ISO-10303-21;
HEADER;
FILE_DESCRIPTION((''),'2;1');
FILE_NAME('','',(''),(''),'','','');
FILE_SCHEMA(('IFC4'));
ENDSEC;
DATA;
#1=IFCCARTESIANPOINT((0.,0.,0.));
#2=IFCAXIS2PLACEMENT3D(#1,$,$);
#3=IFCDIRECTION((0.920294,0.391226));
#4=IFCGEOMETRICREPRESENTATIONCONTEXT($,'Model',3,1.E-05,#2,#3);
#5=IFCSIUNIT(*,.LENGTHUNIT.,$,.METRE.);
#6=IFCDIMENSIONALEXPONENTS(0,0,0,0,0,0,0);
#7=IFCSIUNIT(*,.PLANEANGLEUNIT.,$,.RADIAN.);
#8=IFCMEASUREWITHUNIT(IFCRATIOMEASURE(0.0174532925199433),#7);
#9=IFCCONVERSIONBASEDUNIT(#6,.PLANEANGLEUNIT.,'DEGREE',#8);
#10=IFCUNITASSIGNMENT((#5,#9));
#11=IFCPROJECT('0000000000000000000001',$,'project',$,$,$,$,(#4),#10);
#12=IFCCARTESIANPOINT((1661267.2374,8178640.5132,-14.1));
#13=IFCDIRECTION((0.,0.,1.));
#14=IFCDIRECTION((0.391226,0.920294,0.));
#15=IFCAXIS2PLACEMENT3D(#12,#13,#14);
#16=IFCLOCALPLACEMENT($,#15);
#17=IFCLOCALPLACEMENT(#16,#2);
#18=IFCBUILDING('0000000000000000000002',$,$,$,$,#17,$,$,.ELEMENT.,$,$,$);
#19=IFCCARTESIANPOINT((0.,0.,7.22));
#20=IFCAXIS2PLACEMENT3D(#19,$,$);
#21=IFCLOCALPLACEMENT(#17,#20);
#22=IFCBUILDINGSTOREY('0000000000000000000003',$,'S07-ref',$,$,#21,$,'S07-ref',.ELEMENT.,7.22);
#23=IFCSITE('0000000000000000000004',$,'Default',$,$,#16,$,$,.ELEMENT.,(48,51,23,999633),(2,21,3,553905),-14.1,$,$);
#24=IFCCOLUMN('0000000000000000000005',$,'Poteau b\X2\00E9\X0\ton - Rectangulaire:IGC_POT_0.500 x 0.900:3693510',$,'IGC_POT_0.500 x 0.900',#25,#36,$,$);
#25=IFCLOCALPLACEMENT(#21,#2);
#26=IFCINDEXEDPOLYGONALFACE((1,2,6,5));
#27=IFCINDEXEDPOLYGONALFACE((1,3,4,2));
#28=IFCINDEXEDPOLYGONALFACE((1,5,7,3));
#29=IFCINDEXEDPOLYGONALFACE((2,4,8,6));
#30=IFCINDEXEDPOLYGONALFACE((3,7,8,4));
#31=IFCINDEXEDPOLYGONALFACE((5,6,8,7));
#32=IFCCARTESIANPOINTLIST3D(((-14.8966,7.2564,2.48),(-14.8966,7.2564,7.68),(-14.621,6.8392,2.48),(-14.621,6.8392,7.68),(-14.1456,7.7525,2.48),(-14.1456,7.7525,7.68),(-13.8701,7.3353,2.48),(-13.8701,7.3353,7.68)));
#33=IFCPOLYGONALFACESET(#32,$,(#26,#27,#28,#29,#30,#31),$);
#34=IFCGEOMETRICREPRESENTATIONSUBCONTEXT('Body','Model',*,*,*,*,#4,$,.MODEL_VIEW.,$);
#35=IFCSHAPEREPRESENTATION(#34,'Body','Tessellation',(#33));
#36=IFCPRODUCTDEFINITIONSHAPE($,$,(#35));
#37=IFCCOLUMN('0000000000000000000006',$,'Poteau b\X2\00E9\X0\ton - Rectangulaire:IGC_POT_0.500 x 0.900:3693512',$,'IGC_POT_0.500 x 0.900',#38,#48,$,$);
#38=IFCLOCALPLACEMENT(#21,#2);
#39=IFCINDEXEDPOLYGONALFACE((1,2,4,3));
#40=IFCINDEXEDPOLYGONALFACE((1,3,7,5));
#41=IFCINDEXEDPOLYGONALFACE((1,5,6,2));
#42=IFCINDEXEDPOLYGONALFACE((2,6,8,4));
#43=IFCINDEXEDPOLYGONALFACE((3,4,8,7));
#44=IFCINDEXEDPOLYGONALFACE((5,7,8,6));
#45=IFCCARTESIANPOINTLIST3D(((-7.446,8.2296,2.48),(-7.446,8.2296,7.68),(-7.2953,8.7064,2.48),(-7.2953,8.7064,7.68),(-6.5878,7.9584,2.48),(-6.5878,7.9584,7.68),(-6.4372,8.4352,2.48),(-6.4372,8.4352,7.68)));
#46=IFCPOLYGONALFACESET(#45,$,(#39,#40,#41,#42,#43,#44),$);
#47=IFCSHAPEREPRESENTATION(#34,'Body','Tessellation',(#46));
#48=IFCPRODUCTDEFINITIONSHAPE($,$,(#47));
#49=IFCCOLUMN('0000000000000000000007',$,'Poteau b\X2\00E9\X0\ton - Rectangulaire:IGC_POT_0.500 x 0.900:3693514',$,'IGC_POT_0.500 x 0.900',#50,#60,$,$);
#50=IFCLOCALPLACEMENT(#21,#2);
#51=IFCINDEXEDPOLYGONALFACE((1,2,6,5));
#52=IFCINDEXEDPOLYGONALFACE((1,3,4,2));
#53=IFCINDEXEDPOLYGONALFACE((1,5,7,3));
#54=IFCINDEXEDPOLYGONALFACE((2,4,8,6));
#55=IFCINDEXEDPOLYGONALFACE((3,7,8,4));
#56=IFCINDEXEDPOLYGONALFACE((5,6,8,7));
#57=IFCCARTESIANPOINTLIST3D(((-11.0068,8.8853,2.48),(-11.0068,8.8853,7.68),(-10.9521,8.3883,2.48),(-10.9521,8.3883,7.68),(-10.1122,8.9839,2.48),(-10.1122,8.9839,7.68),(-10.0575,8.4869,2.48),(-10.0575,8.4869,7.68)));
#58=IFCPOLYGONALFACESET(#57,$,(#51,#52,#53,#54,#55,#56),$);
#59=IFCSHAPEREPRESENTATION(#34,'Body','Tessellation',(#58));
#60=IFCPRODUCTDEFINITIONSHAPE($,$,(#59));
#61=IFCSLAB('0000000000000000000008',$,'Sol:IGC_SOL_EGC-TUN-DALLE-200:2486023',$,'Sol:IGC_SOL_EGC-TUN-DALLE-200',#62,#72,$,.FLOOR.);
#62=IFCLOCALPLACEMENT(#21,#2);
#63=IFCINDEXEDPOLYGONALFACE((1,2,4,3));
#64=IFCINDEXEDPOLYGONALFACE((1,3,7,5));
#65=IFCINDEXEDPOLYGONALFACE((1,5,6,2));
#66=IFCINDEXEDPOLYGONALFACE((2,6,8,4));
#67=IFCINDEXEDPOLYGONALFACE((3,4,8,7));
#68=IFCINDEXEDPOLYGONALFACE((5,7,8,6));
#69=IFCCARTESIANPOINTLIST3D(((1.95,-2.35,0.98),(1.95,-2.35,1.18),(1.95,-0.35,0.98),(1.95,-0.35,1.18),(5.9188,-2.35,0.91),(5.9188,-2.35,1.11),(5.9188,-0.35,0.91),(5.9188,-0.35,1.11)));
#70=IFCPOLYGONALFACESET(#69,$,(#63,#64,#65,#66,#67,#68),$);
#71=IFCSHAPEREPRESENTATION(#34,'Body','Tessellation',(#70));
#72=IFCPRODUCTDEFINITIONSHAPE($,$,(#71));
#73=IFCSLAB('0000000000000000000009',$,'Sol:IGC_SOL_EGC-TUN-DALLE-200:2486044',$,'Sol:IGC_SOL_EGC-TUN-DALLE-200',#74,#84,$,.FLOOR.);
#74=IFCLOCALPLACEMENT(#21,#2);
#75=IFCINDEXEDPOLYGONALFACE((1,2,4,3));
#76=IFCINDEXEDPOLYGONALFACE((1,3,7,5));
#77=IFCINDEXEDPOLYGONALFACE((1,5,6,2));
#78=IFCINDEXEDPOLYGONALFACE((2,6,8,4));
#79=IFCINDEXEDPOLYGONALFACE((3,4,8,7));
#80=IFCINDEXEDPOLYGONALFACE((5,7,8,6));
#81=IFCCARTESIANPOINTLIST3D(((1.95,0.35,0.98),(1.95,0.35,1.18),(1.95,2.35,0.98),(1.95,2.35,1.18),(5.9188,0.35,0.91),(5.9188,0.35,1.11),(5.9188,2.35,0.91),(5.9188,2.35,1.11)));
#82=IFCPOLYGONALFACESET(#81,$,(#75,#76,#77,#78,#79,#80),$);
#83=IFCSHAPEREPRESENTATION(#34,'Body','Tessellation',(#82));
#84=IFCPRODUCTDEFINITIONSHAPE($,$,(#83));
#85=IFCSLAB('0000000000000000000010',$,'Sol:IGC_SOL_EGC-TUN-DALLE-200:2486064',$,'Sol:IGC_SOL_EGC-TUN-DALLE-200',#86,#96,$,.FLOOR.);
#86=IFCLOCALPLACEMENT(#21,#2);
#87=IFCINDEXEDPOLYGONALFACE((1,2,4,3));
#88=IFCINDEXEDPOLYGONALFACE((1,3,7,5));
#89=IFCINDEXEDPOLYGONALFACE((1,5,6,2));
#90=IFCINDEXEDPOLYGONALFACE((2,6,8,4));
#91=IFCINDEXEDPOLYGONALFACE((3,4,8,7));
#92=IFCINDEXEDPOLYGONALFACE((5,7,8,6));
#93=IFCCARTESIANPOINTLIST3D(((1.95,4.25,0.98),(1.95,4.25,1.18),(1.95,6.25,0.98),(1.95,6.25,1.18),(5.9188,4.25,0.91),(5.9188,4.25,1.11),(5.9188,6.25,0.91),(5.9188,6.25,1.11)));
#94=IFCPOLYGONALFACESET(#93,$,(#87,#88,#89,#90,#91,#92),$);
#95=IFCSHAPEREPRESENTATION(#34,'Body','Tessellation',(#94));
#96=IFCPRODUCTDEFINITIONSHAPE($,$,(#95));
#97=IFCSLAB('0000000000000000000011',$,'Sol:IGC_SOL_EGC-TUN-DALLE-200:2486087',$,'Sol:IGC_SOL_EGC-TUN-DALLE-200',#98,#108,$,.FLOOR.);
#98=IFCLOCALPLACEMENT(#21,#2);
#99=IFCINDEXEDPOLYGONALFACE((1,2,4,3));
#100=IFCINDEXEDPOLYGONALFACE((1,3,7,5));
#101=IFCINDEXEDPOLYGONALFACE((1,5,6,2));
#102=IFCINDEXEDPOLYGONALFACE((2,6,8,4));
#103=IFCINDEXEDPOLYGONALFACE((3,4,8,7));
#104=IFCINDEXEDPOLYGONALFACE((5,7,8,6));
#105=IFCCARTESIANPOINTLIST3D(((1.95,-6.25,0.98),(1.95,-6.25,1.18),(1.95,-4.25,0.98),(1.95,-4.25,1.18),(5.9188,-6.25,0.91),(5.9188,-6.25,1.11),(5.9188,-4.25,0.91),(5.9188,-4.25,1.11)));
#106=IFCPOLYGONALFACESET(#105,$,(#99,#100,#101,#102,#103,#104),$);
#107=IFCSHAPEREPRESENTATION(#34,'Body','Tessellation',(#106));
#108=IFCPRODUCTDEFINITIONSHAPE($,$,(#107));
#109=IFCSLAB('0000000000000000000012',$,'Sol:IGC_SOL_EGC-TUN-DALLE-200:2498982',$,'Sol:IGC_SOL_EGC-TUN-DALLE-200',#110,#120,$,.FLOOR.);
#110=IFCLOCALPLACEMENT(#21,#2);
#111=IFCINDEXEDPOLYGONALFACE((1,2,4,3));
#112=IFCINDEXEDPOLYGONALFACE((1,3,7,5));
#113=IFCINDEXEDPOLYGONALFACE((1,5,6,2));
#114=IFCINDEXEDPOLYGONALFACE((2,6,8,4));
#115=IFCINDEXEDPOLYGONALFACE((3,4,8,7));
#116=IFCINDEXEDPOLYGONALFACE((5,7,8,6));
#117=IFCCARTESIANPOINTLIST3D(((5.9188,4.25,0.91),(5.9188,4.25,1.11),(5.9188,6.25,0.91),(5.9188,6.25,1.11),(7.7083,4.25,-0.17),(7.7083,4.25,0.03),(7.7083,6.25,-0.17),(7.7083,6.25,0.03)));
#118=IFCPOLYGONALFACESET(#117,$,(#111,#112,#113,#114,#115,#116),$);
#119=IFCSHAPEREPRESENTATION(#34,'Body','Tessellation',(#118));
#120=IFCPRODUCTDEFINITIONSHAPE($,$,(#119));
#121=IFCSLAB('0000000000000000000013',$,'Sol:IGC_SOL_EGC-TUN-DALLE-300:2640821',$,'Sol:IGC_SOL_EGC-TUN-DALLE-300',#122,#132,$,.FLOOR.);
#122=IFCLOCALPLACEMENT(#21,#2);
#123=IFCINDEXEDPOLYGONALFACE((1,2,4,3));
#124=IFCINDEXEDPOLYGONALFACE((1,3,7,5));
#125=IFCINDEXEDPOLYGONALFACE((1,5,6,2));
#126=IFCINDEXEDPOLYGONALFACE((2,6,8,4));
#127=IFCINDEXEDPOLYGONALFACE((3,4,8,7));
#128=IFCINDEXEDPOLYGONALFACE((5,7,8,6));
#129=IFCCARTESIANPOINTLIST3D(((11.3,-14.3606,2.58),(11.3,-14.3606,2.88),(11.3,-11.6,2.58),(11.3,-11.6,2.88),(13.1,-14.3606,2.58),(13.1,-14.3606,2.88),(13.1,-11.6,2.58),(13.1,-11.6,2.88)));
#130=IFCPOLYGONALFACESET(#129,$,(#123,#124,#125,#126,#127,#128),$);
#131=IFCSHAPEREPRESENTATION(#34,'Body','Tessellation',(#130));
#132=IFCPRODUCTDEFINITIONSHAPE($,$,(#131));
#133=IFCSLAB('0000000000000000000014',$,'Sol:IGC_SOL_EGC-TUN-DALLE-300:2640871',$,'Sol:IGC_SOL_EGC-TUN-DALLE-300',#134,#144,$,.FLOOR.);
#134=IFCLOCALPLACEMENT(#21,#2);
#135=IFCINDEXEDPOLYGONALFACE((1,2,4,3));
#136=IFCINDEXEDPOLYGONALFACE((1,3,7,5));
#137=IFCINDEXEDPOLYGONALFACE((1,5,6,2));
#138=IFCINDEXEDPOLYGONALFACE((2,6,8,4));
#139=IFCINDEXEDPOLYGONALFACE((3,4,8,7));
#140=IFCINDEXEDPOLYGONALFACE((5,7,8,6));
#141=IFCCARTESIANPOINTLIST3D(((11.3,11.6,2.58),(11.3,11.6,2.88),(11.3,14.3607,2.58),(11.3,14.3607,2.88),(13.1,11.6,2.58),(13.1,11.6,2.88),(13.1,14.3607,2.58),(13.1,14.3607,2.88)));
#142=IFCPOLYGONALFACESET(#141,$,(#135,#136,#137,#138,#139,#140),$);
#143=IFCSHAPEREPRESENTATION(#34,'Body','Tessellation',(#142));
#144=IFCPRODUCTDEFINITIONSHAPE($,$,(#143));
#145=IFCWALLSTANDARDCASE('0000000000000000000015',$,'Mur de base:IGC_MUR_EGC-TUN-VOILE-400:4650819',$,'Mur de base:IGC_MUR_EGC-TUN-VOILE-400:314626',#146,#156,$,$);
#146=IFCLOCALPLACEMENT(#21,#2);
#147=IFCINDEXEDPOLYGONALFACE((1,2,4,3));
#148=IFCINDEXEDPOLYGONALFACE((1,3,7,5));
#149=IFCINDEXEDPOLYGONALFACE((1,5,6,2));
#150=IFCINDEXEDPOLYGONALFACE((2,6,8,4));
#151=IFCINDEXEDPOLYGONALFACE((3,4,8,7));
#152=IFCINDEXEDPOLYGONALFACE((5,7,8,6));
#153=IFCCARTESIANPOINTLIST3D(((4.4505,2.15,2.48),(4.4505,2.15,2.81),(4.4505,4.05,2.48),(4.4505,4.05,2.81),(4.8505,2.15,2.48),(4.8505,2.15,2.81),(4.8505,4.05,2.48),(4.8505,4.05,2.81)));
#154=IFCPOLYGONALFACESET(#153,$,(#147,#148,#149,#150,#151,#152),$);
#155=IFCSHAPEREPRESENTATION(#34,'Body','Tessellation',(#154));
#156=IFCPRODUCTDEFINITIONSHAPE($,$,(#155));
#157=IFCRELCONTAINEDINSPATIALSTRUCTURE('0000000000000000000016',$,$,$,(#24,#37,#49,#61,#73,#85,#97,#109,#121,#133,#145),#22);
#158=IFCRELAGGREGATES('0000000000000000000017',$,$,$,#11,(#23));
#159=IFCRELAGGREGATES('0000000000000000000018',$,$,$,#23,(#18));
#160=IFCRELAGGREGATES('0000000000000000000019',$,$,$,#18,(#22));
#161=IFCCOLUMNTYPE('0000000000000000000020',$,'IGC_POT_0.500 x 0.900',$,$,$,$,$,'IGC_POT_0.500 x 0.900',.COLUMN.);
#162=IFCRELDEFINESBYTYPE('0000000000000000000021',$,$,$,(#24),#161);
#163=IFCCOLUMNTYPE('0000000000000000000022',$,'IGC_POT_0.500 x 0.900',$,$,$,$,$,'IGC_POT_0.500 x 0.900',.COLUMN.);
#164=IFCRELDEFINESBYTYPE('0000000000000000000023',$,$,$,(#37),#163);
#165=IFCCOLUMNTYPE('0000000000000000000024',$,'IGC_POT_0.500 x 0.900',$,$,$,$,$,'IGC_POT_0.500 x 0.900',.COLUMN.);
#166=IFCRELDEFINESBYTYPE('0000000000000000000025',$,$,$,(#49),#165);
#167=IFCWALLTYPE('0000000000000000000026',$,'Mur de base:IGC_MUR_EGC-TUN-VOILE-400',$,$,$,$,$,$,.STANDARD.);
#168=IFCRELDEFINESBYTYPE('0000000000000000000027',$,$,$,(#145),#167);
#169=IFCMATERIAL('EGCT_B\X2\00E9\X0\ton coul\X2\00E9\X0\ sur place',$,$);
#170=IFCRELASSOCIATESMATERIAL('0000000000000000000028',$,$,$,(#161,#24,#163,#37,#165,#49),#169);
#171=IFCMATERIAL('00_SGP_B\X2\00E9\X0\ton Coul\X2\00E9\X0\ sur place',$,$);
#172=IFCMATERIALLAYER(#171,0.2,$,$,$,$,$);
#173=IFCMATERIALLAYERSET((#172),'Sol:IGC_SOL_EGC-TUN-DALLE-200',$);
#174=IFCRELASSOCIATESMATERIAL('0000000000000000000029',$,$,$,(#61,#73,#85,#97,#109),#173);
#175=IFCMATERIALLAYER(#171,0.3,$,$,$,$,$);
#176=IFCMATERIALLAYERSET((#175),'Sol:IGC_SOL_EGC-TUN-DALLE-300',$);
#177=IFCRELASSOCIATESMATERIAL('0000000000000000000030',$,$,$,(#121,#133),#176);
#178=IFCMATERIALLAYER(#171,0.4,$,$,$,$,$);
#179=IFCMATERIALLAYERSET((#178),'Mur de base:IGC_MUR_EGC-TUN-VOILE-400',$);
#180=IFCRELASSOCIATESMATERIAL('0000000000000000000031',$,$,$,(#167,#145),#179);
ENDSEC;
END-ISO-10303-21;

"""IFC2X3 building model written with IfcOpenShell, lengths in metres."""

from ifc_helpers import new_model, entity, si_unit, converted_unit, direction, frame, frame_2d, origin, origin_2d_with_axis, place, context, subcontext, project, spatial, polyline, rectangle, outline, extrude, clip, halfspace, source, transform, mapped, material, layer, layer_set, layer_usage, type_object, type_shapes, element, save


model = new_model("IFC2X3")

# Units and contexts
model_context = context("Model", 3, precision=1e-05, world=origin(), true_north=direction((0.920294, 0.391226)))
body_context = subcontext(model_context, "Body", "Model", "MODEL_VIEW")
ifc_project = project(units=[si_unit("LENGTHUNIT", "METRE"), converted_unit("PLANEANGLEUNIT", "DEGREE", entity("IfcRatioMeasure", 0.0174532925199433), si_unit("PLANEANGLEUNIT", "RADIAN"), dimensions=[0, 0, 0, 0, 0, 0, 0])], contexts=[model_context])

# Site, building, storey
site_placement = place(None, frame((1661267.2374, 8178640.5132, -14.1), z_axis=(0.0, 0.0, 1.0), x_axis=(0.391226, 0.920294, 0.0)))
site = spatial("IfcSite", under=ifc_project, at=site_placement, Name="Default", CompositionType="ELEMENT", RefLatitude=(48, 51, 23, 999633), RefLongitude=(2, 21, 3, 553905), RefElevation=-14.1)
building_placement = place(site_placement, origin())
building = spatial("IfcBuilding", under=site, at=building_placement, CompositionType="ELEMENT")
storey_placement = place(building_placement, frame((0.0, 0.0, 7.22)))
storey = spatial("IfcBuildingStorey", under=building, at=storey_placement, Name="S07-ref", LongName="S07-ref", CompositionType="ELEMENT", Elevation=7.22)

# Columns
ifc_material_1 = material(Name="EGCT_Béton coulé sur place")
column_type_1 = type_object("IfcColumnType", Name="IGC_POT_0.500 x 0.900", ElementType="IGC_POT_0.500 x 0.900", PredefinedType="COLUMN", material=ifc_material_1)
shared_shape_1 = source(origin(), body_context, "Body", "SweptSolid", [
    extrude(rectangle(XDim=0.5, YDim=0.9, at=origin_2d_with_axis()), frame((-14.3833, 7.2959, 9.7), z_axis=(0.0, 0.0, 1.0), x_axis=(-0.551164, 0.834397, 0.0)), (0.0, 0.0, 1.0), 5.2),
])
type_shapes(column_type_1, [shared_shape_1])
column_1_placement = place(storey_placement, frame((0.0, 0.0, -7.22)))
element("IfcColumn", 1, at=column_1_placement, inside=storey, type_object=column_type_1, material=ifc_material_1, Name="Poteau béton - Rectangulaire:IGC_POT_0.500 x 0.900:3693510", ObjectType="IGC_POT_0.500 x 0.900", context=body_context, shape_type="MappedRepresentation", body=[
    mapped(shared_shape_1, transform((0.0, 0.0, 0.0), scale=1.0)),
])
column_type_2 = type_object("IfcColumnType", Name="IGC_POT_0.500 x 0.900", ElementType="IGC_POT_0.500 x 0.900", PredefinedType="COLUMN", material=ifc_material_1)
shared_shape_2 = source(origin(), body_context, "Body", "SweptSolid", [
    extrude(rectangle(XDim=0.9, YDim=0.5, at=origin_2d_with_axis()), frame((-6.9416, 8.3324, 9.7), z_axis=(0.0, 0.0, 1.0), x_axis=(-0.953513, 0.301352, 0.0)), (0.0, 0.0, 1.0), 5.2),
])
type_shapes(column_type_2, [shared_shape_2])
column_2_placement = place(storey_placement, frame((0.0, 0.0, -7.22)))
element("IfcColumn", 2, at=column_2_placement, inside=storey, type_object=column_type_2, material=ifc_material_1, Name="Poteau béton - Rectangulaire:IGC_POT_0.500 x 0.900:3693512", ObjectType="IGC_POT_0.500 x 0.900", context=body_context, shape_type="MappedRepresentation", body=[
    mapped(shared_shape_2, transform((0.0, 0.0, 0.0), scale=1.0)),
])
column_type_3 = type_object("IfcColumnType", Name="IGC_POT_0.500 x 0.900", ElementType="IGC_POT_0.500 x 0.900", PredefinedType="COLUMN", material=ifc_material_1)
shared_shape_3 = source(origin(), body_context, "Body", "SweptSolid", [
    extrude(rectangle(XDim=0.9, YDim=0.5, at=frame_2d((0.0, 0.0), x_axis=(1.0, 0.0))), frame((-10.5321, 8.6861, 9.7), z_axis=(0.0, 0.0, 1.0), x_axis=(-0.993983, -0.10953, 0.0)), (0.0, 0.0, 1.0), 5.2),
])
type_shapes(column_type_3, [shared_shape_3])
column_3_placement = place(storey_placement, frame((0.0, 0.0, -7.22)))
element("IfcColumn", 3, at=column_3_placement, inside=storey, type_object=column_type_3, material=ifc_material_1, Name="Poteau béton - Rectangulaire:IGC_POT_0.500 x 0.900:3693514", ObjectType="IGC_POT_0.500 x 0.900", context=body_context, shape_type="MappedRepresentation", body=[
    mapped(shared_shape_3, transform((0.0, 0.0, 0.0), scale=1.0)),
])

# Slabs
ifc_material_2 = material(Name="00_SGP_Béton Coulé sur place")
ifc_layer_1 = layer(ifc_material_2, 0.2)
ifc_layer_set_1 = layer_set([ifc_layer_1], Name="Sol:IGC_SOL_EGC-TUN-DALLE-200")
ifc_layer_usage_1 = layer_usage(ifc_layer_set_1, "AXIS3", "POSITIVE", 0.0)
slab_1_placement = place(storey_placement, origin())
element("IfcSlab", 4, at=slab_1_placement, inside=storey, material=ifc_layer_usage_1, Name="Sol:IGC_SOL_EGC-TUN-DALLE-200:2486023", ObjectType="Sol:IGC_SOL_EGC-TUN-DALLE-200", PredefinedType="FLOOR", context=body_context, shape_type="Clipping", body=[
    clip(clip(extrude(rectangle(XDim=3.9694, YDim=2.0, at=frame_2d((0.0, 0.0), x_axis=(0.0, 1.0))), frame((3.9344, -1.35, 1.145), z_axis=(-0.017635, 0.0, -0.999844), x_axis=(0.0, 1.0, 0.0)), (0.0, 0.017635, 0.999844), 0.2), halfspace(frame((3.9344, -1.35, 0.945), z_axis=(-0.017635, 0.0, -0.999844), x_axis=(0.0, -1.0, 0.0)), False)), halfspace(frame((3.9344, -1.35, 1.145), z_axis=(0.017635, 0.0, 0.999844), x_axis=(0.0, -1.0, 0.0)), False)),
])
ifc_layer_usage_2 = layer_usage(ifc_layer_set_1, "AXIS3", "POSITIVE", 0.0)
slab_2_placement = place(storey_placement, origin())
element("IfcSlab", 5, at=slab_2_placement, inside=storey, material=ifc_layer_usage_2, Name="Sol:IGC_SOL_EGC-TUN-DALLE-200:2486044", ObjectType="Sol:IGC_SOL_EGC-TUN-DALLE-200", PredefinedType="FLOOR", context=body_context, shape_type="Clipping", body=[
    clip(clip(extrude(rectangle(XDim=3.9694, YDim=2.0, at=frame_2d((0.0, 0.0), x_axis=(0.0, 1.0))), frame((3.9344, 1.35, 1.145), z_axis=(-0.017635, 0.0, -0.999844), x_axis=(0.0, 1.0, 0.0)), (0.0, 0.017635, 0.999844), 0.2), halfspace(frame((3.9344, 1.35, 0.945), z_axis=(-0.017635, 0.0, -0.999844), x_axis=(-0.999844, 0.0, 0.017635)), False)), halfspace(frame((3.9344, 1.35, 1.145), z_axis=(0.017635, 0.0, 0.999844), x_axis=(-0.999844, 0.0, 0.017635)), False)),
])
ifc_layer_usage_3 = layer_usage(ifc_layer_set_1, "AXIS3", "POSITIVE", 0.0)
slab_3_placement = place(storey_placement, origin())
element("IfcSlab", 6, at=slab_3_placement, inside=storey, material=ifc_layer_usage_3, Name="Sol:IGC_SOL_EGC-TUN-DALLE-200:2486064", ObjectType="Sol:IGC_SOL_EGC-TUN-DALLE-200", PredefinedType="FLOOR", context=body_context, shape_type="Clipping", body=[
    clip(clip(extrude(outline(polyline([(-1.0, -1.9847), (1.0, -1.9847), (1.0, 1.9847), (-1.0, 1.9847), (-1.0, -1.9847)])), frame((3.9344, 5.25, 1.145), z_axis=(-0.017635, 0.0, -0.999844), x_axis=(0.0, 1.0, 0.0)), (0.0, 0.017635, 0.999844), 0.2), halfspace(frame((3.9344, 5.25, 0.945), z_axis=(-0.017635, 0.0, -0.999844), x_axis=(0.999844, 0.0, -0.017635)), False)), halfspace(frame((3.9344, 5.25, 1.145), z_axis=(0.017635, 0.0, 0.999844), x_axis=(0.999844, 0.0, -0.017635)), False)),
])
ifc_layer_usage_4 = layer_usage(ifc_layer_set_1, "AXIS3", "POSITIVE", 0.0)
slab_4_placement = place(storey_placement, origin())
element("IfcSlab", 7, at=slab_4_placement, inside=storey, material=ifc_layer_usage_4, Name="Sol:IGC_SOL_EGC-TUN-DALLE-200:2486087", ObjectType="Sol:IGC_SOL_EGC-TUN-DALLE-200", PredefinedType="FLOOR", context=body_context, shape_type="Clipping", body=[
    clip(clip(extrude(rectangle(XDim=3.9694, YDim=2.0, at=frame_2d((0.0, 0.0), x_axis=(0.0, 1.0))), frame((3.9344, -5.25, 1.145), z_axis=(-0.017635, 0.0, -0.999844), x_axis=(0.0, 1.0, 0.0)), (0.0, 0.017635, 0.999844), 0.2), halfspace(frame((3.9344, -5.25, 0.945), z_axis=(-0.017635, 0.0, -0.999844), x_axis=(-0.999844, 0.0, 0.017635)), False)), halfspace(frame((3.9344, -5.25, 1.145), z_axis=(0.017635, 0.0, 0.999844), x_axis=(-0.999844, 0.0, 0.017635)), False)),
])
ifc_layer_usage_5 = layer_usage(ifc_layer_set_1, "AXIS3", "POSITIVE", 0.0)
slab_5_placement = place(storey_placement, frame((5.9188, 4.25, -0.17)))
element("IfcSlab", 8, at=slab_5_placement, inside=storey, material=ifc_layer_usage_5, Name="Sol:IGC_SOL_EGC-TUN-DALLE-200:2498982", ObjectType="Sol:IGC_SOL_EGC-TUN-DALLE-200", PredefinedType="FLOOR", context=body_context, shape_type="SweptSolid", body=[
    extrude(outline(polyline([(-1.0451, -1.0), (1.0451, -1.0), (1.0451, 1.0), (-1.0451, 1.0), (-1.0451, -1.0)])), frame((0.8948, 1.0, 0.74), z_axis=(0.516703, 0.0, 0.856165), x_axis=(0.856165, 0.0, -0.516703)), (0.516703, 0.0, -0.856165), 0.2),
])
ifc_layer_2 = layer(ifc_material_2, 0.3)
ifc_layer_set_2 = layer_set([ifc_layer_2], Name="Sol:IGC_SOL_EGC-TUN-DALLE-300")
ifc_layer_usage_6 = layer_usage(ifc_layer_set_2, "AXIS3", "POSITIVE", 0.0)
slab_6_placement = place(storey_placement, origin())
element("IfcSlab", 9, at=slab_6_placement, inside=storey, material=ifc_layer_usage_6, Name="Sol:IGC_SOL_EGC-TUN-DALLE-300:2640821", ObjectType="Sol:IGC_SOL_EGC-TUN-DALLE-300", PredefinedType="FLOOR", context=body_context, shape_type="SweptSolid", body=[
    extrude(outline(polyline([(-1.3803, -0.9), (1.3803, -0.9), (1.3803, 0.9), (-1.3803, 0.9), (-1.3803, -0.9)])), frame((12.2, -12.9803, 2.88), z_axis=(0.0, 0.0, -1.0), x_axis=(0.0, 1.0, 0.0)), (0.0, 0.0, 1.0), 0.3),
])
ifc_layer_usage_7 = layer_usage(ifc_layer_set_2, "AXIS3", "POSITIVE", 0.0)
slab_7_placement = place(storey_placement, origin())
element("IfcSlab", 10, at=slab_7_placement, inside=storey, material=ifc_layer_usage_7, Name="Sol:IGC_SOL_EGC-TUN-DALLE-300:2640871", ObjectType="Sol:IGC_SOL_EGC-TUN-DALLE-300", PredefinedType="FLOOR", context=body_context, shape_type="SweptSolid", body=[
    extrude(outline(polyline([(-1.3803, -0.9), (1.3803, -0.9), (1.3803, 0.9), (-1.3803, 0.9), (-1.3803, -0.9)])), frame((12.2, 12.9804, 2.88), z_axis=(0.0, 0.0, -1.0), x_axis=(0.0, 1.0, 0.0)), (0.0, 0.0, 1.0), 0.3),
])

# Wall
ifc_layer_3 = layer(ifc_material_2, 0.4)
ifc_layer_set_3 = layer_set([ifc_layer_3], Name="Mur de base:IGC_MUR_EGC-TUN-VOILE-400")
ifc_layer_usage_8 = layer_usage(ifc_layer_set_3, "AXIS2", "NEGATIVE", 0.2)
wall_type_1 = type_object("IfcWallType", Name="Mur de base:IGC_MUR_EGC-TUN-VOILE-400", PredefinedType="STANDARD", material=ifc_layer_set_3)
wall_1_placement = place(storey_placement, frame((4.6505, 2.15, 2.48), z_axis=(0.0, 0.0, 1.0), x_axis=(0.0, 1.0, 0.0)))
element("IfcWallStandardCase", 11, at=wall_1_placement, inside=storey, type_object=wall_type_1, material=ifc_layer_usage_8, Name="Mur de base:IGC_MUR_EGC-TUN-VOILE-400:4650819", ObjectType="Mur de base:IGC_MUR_EGC-TUN-VOILE-400:314626", context=body_context, shape_type="SweptSolid", body=[
    extrude(rectangle(XDim=1.9, YDim=0.4, at=frame_2d((0.95, 0.0), x_axis=(-1.0, 0.0))), origin(), (0.0, 0.0, 1.0), 0.33),
])

save(model, "model.ifc")
